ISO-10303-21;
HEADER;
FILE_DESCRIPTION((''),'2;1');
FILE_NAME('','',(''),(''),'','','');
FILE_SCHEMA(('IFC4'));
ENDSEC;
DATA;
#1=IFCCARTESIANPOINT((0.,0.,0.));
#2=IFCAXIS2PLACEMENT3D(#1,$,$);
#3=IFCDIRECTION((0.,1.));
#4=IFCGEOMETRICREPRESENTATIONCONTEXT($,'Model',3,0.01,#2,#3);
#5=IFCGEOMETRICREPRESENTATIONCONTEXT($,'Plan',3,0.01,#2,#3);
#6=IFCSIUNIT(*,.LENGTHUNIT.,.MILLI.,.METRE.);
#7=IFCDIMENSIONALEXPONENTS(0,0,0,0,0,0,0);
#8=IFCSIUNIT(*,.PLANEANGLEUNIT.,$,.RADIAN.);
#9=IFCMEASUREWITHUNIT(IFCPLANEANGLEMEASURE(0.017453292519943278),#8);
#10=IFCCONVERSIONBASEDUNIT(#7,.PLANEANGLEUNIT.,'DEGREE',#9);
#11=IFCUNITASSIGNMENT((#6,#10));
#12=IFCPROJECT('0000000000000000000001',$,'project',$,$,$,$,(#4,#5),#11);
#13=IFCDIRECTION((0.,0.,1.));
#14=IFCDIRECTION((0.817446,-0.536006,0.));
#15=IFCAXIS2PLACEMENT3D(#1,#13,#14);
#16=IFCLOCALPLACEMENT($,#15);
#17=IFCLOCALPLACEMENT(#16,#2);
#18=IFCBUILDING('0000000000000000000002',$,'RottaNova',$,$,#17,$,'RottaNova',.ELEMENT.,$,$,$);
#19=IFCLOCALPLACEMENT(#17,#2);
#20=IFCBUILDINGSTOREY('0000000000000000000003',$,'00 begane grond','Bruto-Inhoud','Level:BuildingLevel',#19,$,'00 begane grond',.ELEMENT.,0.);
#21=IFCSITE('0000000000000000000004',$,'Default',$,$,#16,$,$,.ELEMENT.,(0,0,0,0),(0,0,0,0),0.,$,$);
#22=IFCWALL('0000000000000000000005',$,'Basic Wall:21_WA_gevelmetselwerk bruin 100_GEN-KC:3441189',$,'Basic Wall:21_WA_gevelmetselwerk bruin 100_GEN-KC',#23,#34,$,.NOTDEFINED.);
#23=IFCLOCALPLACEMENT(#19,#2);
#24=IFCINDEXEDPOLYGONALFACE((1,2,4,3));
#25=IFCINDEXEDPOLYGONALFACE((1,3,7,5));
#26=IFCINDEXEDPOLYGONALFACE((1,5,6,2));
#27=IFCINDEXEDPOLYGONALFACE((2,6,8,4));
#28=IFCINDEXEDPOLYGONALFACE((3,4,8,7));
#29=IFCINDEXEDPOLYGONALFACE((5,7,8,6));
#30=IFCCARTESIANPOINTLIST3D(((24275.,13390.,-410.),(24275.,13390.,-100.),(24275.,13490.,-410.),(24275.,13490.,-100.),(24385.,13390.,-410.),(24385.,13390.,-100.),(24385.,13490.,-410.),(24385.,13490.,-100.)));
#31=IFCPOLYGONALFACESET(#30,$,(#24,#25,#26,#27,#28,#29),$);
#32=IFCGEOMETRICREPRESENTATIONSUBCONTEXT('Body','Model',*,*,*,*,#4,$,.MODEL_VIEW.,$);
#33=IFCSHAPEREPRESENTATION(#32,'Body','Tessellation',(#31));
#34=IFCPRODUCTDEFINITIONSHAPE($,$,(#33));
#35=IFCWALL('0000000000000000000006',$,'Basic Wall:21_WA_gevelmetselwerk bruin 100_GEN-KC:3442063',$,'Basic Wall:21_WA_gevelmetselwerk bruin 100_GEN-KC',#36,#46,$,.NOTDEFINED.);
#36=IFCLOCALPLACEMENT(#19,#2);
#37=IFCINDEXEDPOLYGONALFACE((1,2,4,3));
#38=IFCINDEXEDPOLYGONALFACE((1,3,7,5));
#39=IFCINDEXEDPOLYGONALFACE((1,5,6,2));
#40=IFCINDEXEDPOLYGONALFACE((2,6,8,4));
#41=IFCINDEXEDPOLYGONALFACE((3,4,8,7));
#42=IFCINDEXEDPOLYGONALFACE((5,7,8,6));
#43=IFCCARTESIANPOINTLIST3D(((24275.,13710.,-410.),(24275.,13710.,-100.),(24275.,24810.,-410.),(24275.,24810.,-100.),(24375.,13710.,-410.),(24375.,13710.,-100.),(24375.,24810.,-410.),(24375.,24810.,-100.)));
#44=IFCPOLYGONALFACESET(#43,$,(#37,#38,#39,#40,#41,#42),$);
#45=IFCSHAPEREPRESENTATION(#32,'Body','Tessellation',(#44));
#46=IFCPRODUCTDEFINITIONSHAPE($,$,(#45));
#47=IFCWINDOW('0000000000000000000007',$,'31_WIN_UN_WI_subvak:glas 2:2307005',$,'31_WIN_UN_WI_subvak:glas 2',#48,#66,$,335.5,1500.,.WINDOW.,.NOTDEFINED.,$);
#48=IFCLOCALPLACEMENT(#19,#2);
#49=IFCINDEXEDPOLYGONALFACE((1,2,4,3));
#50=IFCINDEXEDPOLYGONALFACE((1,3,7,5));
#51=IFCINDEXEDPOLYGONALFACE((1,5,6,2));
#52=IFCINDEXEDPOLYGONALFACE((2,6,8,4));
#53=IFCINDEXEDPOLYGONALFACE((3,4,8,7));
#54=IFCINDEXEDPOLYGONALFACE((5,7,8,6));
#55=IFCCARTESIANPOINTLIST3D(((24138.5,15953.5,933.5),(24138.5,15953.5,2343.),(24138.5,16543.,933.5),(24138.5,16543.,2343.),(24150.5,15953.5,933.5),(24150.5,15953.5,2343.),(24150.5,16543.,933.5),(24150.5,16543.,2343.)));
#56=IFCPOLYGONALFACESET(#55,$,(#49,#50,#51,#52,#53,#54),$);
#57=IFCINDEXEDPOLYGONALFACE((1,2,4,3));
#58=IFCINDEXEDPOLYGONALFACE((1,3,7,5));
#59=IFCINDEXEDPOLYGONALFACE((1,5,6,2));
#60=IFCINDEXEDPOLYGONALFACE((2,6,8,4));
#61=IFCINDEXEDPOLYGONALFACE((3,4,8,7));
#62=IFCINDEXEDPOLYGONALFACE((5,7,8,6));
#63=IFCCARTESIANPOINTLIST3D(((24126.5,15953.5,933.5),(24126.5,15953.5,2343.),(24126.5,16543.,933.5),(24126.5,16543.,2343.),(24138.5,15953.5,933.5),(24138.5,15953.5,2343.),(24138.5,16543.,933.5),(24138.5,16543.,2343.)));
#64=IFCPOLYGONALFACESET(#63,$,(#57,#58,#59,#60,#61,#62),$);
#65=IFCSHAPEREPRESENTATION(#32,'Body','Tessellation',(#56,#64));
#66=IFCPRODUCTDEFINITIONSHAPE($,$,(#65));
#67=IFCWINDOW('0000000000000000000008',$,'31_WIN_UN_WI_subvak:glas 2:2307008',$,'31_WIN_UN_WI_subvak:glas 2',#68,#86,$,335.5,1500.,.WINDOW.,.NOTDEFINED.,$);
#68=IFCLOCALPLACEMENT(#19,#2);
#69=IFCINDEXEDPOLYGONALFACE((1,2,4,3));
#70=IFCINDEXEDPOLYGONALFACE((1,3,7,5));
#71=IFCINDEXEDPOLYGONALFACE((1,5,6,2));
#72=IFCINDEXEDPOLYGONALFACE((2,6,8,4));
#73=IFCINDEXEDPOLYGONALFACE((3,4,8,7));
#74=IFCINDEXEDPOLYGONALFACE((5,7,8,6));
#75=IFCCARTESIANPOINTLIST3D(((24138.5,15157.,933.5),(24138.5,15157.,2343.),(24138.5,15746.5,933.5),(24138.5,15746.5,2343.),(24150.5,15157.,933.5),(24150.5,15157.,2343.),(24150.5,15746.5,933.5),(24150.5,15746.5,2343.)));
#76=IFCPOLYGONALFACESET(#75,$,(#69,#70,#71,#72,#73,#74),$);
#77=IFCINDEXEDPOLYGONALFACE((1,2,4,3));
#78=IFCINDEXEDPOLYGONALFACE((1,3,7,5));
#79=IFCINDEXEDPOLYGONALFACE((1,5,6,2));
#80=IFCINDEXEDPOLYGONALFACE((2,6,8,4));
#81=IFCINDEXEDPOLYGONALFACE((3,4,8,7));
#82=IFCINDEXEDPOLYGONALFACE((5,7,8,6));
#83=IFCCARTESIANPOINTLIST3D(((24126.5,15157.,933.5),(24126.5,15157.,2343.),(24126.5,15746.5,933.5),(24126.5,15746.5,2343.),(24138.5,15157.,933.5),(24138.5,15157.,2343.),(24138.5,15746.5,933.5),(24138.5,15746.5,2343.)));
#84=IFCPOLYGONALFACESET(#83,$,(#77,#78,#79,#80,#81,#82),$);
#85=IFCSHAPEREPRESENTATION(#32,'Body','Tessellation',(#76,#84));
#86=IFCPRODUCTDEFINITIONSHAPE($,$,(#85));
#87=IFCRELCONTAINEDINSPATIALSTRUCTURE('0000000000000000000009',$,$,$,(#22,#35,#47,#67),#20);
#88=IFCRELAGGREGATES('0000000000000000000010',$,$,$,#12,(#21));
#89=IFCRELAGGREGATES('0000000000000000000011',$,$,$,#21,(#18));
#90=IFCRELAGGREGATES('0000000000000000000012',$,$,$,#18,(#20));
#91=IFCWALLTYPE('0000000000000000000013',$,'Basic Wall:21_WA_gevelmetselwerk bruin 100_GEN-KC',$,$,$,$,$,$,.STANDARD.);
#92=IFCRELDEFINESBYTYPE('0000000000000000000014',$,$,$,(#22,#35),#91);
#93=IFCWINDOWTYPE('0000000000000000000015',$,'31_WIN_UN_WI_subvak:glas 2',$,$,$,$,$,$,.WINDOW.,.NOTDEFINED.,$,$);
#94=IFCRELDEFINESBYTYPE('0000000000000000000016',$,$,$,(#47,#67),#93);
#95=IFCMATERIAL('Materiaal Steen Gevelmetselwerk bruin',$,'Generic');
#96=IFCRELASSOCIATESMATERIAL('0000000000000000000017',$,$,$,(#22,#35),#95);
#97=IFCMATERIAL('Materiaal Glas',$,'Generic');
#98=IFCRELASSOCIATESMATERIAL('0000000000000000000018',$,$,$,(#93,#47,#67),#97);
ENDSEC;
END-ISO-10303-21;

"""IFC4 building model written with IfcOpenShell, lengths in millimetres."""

from ifc_helpers import new_model, entity, si_unit, converted_unit, direction, frame, origin, place, context, subcontext, project, spatial, indexed_curve, outline, extrude, source, transform, mapped, material, type_object, type_shapes, element, save


model = new_model("IFC4")

# Units and contexts
model_context = context("Model", 3, precision=0.01, world=origin(), true_north=direction((0.0, 1.0)))
plan_context = context("Plan", 3, precision=0.01, world=origin(), true_north=direction((0.0, 1.0)))
body_context = subcontext(model_context, "Body", "Model", "MODEL_VIEW")
ifc_project = project(units=[si_unit("LENGTHUNIT", "METRE", prefix="MILLI"), converted_unit("PLANEANGLEUNIT", "DEGREE", entity("IfcPlaneAngleMeasure", 0.017453292519943278), si_unit("PLANEANGLEUNIT", "RADIAN"), dimensions=[0, 0, 0, 0, 0, 0, 0])], contexts=[model_context, plan_context])

# Site, building, storey
site_placement = place(None, frame((0.0, 0.0, 0.0), z_axis=(0.0, 0.0, 1.0), x_axis=(0.817446, -0.536006, 0.0)))
site = spatial("IfcSite", under=ifc_project, at=site_placement, Name="Default", CompositionType="ELEMENT", RefLatitude=(0, 0, 0, 0), RefLongitude=(0, 0, 0, 0), RefElevation=0.0)
building_placement = place(site_placement, origin())
building = spatial("IfcBuilding", under=site, at=building_placement, Name="RottaNova", LongName="RottaNova", CompositionType="ELEMENT")
storey_placement = place(building_placement, origin())
storey = spatial("IfcBuildingStorey", under=building, at=storey_placement, Name="00 begane grond", Description="Bruto-Inhoud", ObjectType="Level:BuildingLevel", LongName="00 begane grond", CompositionType="ELEMENT", Elevation=0.0)

# Shared definitions
ifc_material_1 = material(Name="Materiaal Glas", Category="Generic")

# Walls
ifc_material_2 = material(Name="Materiaal Steen Gevelmetselwerk bruin", Category="Generic")
wall_type_1 = type_object("IfcWallType", Name="Basic Wall:21_WA_gevelmetselwerk bruin 100_GEN-KC", PredefinedType="STANDARD")
wall_1_placement = place(storey_placement, frame((24385.0, 13440.0, -410.0), z_axis=(0.0, 0.0, 1.0), x_axis=(-1.0, 0.0, 0.0)))
element("IfcWall", 1, at=wall_1_placement, inside=storey, type_object=wall_type_1, material=ifc_material_2, Name="Basic Wall:21_WA_gevelmetselwerk bruin 100_GEN-KC:3441189", ObjectType="Basic Wall:21_WA_gevelmetselwerk bruin 100_GEN-KC", PredefinedType="NOTDEFINED", context=body_context, shape_type="SweptSolid", body=[
    extrude(outline(indexed_curve([(110.0, 50.0), (0.0, 50.0), (0.0, -50.0), (110.0, -50.0), (110.0, 50.0)], self_intersect=False)), origin(), (0.0, 0.0, 1.0), 310.0),
])
wall_2_placement = place(storey_placement, frame((24325.0, 13710.0, -410.0), z_axis=(0.0, 0.0, 1.0), x_axis=(0.0, 1.0, 0.0)))
element("IfcWall", 2, at=wall_2_placement, inside=storey, type_object=wall_type_1, material=ifc_material_2, Name="Basic Wall:21_WA_gevelmetselwerk bruin 100_GEN-KC:3442063", ObjectType="Basic Wall:21_WA_gevelmetselwerk bruin 100_GEN-KC", PredefinedType="NOTDEFINED", context=body_context, shape_type="SweptSolid", body=[
    extrude(outline(indexed_curve([(11100.0, 50.0), (0.0, 50.0), (0.0, -50.0), (11100.0, -50.0), (11100.0, 50.0)], self_intersect=False)), origin(), (0.0, 0.0, 1.0), 310.0),
])

# Windows
window_type = type_object("IfcWindowType", Name="31_WIN_UN_WI_subvak:glas 2", PartitioningType="NOTDEFINED", PredefinedType="WINDOW", material=ifc_material_1)
shared_shape_1 = source(origin(), body_context, "Body", "SweptSolid", [
    extrude(outline(indexed_curve([(-6.0, -294.7), (6.0, -294.7), (6.0, 294.7), (-6.0, 294.7), (-6.0, -294.7)], self_intersect=False)), frame((0.0, 6.0, 0.0), z_axis=(0.0, 0.0, 1.0), x_axis=(0.0, -1.0, 0.0)), (0.0, 0.0, 1.0), 1409.5),
    extrude(outline(indexed_curve([(-6.0, -294.8), (6.0, -294.8), (6.0, 294.8), (-6.0, 294.8), (-6.0, -294.8)], self_intersect=False)), frame((0.0, -6.0, 0.0), z_axis=(0.0, 0.0, 1.0), x_axis=(0.0, -1.0, 0.0)), (0.0, 0.0, 1.0), 1409.5),
])
type_shapes(window_type, [shared_shape_1])
for number, where, z_axis, x_axis, name in (
    (3, (24138.5, 16248.3, 933.5), (0.0, 0.0, 1.0), (0.0, -1.0, 0.0), "31_WIN_UN_WI_subvak:glas 2:2307005"),
    (4, (24138.5, 15451.8, 933.5), (0.0, 0.0, 1.0), (0.0, -1.0, 0.0), "31_WIN_UN_WI_subvak:glas 2:2307008"),
):
    element("IfcWindow", number, at=place(storey_placement, frame(where, z_axis=z_axis, x_axis=x_axis)), inside=storey, type_object=window_type, material=ifc_material_1, Name=name, ObjectType="31_WIN_UN_WI_subvak:glas 2", OverallHeight=335.5, OverallWidth=1500.0, PartitioningType="NOTDEFINED", PredefinedType="WINDOW", context=body_context, shape_type="MappedRepresentation", body=[
        mapped(shared_shape_1, transform((0.0, 0.0, 0.0), scale=1.0)),
    ])

save(model, "model.ifc")
